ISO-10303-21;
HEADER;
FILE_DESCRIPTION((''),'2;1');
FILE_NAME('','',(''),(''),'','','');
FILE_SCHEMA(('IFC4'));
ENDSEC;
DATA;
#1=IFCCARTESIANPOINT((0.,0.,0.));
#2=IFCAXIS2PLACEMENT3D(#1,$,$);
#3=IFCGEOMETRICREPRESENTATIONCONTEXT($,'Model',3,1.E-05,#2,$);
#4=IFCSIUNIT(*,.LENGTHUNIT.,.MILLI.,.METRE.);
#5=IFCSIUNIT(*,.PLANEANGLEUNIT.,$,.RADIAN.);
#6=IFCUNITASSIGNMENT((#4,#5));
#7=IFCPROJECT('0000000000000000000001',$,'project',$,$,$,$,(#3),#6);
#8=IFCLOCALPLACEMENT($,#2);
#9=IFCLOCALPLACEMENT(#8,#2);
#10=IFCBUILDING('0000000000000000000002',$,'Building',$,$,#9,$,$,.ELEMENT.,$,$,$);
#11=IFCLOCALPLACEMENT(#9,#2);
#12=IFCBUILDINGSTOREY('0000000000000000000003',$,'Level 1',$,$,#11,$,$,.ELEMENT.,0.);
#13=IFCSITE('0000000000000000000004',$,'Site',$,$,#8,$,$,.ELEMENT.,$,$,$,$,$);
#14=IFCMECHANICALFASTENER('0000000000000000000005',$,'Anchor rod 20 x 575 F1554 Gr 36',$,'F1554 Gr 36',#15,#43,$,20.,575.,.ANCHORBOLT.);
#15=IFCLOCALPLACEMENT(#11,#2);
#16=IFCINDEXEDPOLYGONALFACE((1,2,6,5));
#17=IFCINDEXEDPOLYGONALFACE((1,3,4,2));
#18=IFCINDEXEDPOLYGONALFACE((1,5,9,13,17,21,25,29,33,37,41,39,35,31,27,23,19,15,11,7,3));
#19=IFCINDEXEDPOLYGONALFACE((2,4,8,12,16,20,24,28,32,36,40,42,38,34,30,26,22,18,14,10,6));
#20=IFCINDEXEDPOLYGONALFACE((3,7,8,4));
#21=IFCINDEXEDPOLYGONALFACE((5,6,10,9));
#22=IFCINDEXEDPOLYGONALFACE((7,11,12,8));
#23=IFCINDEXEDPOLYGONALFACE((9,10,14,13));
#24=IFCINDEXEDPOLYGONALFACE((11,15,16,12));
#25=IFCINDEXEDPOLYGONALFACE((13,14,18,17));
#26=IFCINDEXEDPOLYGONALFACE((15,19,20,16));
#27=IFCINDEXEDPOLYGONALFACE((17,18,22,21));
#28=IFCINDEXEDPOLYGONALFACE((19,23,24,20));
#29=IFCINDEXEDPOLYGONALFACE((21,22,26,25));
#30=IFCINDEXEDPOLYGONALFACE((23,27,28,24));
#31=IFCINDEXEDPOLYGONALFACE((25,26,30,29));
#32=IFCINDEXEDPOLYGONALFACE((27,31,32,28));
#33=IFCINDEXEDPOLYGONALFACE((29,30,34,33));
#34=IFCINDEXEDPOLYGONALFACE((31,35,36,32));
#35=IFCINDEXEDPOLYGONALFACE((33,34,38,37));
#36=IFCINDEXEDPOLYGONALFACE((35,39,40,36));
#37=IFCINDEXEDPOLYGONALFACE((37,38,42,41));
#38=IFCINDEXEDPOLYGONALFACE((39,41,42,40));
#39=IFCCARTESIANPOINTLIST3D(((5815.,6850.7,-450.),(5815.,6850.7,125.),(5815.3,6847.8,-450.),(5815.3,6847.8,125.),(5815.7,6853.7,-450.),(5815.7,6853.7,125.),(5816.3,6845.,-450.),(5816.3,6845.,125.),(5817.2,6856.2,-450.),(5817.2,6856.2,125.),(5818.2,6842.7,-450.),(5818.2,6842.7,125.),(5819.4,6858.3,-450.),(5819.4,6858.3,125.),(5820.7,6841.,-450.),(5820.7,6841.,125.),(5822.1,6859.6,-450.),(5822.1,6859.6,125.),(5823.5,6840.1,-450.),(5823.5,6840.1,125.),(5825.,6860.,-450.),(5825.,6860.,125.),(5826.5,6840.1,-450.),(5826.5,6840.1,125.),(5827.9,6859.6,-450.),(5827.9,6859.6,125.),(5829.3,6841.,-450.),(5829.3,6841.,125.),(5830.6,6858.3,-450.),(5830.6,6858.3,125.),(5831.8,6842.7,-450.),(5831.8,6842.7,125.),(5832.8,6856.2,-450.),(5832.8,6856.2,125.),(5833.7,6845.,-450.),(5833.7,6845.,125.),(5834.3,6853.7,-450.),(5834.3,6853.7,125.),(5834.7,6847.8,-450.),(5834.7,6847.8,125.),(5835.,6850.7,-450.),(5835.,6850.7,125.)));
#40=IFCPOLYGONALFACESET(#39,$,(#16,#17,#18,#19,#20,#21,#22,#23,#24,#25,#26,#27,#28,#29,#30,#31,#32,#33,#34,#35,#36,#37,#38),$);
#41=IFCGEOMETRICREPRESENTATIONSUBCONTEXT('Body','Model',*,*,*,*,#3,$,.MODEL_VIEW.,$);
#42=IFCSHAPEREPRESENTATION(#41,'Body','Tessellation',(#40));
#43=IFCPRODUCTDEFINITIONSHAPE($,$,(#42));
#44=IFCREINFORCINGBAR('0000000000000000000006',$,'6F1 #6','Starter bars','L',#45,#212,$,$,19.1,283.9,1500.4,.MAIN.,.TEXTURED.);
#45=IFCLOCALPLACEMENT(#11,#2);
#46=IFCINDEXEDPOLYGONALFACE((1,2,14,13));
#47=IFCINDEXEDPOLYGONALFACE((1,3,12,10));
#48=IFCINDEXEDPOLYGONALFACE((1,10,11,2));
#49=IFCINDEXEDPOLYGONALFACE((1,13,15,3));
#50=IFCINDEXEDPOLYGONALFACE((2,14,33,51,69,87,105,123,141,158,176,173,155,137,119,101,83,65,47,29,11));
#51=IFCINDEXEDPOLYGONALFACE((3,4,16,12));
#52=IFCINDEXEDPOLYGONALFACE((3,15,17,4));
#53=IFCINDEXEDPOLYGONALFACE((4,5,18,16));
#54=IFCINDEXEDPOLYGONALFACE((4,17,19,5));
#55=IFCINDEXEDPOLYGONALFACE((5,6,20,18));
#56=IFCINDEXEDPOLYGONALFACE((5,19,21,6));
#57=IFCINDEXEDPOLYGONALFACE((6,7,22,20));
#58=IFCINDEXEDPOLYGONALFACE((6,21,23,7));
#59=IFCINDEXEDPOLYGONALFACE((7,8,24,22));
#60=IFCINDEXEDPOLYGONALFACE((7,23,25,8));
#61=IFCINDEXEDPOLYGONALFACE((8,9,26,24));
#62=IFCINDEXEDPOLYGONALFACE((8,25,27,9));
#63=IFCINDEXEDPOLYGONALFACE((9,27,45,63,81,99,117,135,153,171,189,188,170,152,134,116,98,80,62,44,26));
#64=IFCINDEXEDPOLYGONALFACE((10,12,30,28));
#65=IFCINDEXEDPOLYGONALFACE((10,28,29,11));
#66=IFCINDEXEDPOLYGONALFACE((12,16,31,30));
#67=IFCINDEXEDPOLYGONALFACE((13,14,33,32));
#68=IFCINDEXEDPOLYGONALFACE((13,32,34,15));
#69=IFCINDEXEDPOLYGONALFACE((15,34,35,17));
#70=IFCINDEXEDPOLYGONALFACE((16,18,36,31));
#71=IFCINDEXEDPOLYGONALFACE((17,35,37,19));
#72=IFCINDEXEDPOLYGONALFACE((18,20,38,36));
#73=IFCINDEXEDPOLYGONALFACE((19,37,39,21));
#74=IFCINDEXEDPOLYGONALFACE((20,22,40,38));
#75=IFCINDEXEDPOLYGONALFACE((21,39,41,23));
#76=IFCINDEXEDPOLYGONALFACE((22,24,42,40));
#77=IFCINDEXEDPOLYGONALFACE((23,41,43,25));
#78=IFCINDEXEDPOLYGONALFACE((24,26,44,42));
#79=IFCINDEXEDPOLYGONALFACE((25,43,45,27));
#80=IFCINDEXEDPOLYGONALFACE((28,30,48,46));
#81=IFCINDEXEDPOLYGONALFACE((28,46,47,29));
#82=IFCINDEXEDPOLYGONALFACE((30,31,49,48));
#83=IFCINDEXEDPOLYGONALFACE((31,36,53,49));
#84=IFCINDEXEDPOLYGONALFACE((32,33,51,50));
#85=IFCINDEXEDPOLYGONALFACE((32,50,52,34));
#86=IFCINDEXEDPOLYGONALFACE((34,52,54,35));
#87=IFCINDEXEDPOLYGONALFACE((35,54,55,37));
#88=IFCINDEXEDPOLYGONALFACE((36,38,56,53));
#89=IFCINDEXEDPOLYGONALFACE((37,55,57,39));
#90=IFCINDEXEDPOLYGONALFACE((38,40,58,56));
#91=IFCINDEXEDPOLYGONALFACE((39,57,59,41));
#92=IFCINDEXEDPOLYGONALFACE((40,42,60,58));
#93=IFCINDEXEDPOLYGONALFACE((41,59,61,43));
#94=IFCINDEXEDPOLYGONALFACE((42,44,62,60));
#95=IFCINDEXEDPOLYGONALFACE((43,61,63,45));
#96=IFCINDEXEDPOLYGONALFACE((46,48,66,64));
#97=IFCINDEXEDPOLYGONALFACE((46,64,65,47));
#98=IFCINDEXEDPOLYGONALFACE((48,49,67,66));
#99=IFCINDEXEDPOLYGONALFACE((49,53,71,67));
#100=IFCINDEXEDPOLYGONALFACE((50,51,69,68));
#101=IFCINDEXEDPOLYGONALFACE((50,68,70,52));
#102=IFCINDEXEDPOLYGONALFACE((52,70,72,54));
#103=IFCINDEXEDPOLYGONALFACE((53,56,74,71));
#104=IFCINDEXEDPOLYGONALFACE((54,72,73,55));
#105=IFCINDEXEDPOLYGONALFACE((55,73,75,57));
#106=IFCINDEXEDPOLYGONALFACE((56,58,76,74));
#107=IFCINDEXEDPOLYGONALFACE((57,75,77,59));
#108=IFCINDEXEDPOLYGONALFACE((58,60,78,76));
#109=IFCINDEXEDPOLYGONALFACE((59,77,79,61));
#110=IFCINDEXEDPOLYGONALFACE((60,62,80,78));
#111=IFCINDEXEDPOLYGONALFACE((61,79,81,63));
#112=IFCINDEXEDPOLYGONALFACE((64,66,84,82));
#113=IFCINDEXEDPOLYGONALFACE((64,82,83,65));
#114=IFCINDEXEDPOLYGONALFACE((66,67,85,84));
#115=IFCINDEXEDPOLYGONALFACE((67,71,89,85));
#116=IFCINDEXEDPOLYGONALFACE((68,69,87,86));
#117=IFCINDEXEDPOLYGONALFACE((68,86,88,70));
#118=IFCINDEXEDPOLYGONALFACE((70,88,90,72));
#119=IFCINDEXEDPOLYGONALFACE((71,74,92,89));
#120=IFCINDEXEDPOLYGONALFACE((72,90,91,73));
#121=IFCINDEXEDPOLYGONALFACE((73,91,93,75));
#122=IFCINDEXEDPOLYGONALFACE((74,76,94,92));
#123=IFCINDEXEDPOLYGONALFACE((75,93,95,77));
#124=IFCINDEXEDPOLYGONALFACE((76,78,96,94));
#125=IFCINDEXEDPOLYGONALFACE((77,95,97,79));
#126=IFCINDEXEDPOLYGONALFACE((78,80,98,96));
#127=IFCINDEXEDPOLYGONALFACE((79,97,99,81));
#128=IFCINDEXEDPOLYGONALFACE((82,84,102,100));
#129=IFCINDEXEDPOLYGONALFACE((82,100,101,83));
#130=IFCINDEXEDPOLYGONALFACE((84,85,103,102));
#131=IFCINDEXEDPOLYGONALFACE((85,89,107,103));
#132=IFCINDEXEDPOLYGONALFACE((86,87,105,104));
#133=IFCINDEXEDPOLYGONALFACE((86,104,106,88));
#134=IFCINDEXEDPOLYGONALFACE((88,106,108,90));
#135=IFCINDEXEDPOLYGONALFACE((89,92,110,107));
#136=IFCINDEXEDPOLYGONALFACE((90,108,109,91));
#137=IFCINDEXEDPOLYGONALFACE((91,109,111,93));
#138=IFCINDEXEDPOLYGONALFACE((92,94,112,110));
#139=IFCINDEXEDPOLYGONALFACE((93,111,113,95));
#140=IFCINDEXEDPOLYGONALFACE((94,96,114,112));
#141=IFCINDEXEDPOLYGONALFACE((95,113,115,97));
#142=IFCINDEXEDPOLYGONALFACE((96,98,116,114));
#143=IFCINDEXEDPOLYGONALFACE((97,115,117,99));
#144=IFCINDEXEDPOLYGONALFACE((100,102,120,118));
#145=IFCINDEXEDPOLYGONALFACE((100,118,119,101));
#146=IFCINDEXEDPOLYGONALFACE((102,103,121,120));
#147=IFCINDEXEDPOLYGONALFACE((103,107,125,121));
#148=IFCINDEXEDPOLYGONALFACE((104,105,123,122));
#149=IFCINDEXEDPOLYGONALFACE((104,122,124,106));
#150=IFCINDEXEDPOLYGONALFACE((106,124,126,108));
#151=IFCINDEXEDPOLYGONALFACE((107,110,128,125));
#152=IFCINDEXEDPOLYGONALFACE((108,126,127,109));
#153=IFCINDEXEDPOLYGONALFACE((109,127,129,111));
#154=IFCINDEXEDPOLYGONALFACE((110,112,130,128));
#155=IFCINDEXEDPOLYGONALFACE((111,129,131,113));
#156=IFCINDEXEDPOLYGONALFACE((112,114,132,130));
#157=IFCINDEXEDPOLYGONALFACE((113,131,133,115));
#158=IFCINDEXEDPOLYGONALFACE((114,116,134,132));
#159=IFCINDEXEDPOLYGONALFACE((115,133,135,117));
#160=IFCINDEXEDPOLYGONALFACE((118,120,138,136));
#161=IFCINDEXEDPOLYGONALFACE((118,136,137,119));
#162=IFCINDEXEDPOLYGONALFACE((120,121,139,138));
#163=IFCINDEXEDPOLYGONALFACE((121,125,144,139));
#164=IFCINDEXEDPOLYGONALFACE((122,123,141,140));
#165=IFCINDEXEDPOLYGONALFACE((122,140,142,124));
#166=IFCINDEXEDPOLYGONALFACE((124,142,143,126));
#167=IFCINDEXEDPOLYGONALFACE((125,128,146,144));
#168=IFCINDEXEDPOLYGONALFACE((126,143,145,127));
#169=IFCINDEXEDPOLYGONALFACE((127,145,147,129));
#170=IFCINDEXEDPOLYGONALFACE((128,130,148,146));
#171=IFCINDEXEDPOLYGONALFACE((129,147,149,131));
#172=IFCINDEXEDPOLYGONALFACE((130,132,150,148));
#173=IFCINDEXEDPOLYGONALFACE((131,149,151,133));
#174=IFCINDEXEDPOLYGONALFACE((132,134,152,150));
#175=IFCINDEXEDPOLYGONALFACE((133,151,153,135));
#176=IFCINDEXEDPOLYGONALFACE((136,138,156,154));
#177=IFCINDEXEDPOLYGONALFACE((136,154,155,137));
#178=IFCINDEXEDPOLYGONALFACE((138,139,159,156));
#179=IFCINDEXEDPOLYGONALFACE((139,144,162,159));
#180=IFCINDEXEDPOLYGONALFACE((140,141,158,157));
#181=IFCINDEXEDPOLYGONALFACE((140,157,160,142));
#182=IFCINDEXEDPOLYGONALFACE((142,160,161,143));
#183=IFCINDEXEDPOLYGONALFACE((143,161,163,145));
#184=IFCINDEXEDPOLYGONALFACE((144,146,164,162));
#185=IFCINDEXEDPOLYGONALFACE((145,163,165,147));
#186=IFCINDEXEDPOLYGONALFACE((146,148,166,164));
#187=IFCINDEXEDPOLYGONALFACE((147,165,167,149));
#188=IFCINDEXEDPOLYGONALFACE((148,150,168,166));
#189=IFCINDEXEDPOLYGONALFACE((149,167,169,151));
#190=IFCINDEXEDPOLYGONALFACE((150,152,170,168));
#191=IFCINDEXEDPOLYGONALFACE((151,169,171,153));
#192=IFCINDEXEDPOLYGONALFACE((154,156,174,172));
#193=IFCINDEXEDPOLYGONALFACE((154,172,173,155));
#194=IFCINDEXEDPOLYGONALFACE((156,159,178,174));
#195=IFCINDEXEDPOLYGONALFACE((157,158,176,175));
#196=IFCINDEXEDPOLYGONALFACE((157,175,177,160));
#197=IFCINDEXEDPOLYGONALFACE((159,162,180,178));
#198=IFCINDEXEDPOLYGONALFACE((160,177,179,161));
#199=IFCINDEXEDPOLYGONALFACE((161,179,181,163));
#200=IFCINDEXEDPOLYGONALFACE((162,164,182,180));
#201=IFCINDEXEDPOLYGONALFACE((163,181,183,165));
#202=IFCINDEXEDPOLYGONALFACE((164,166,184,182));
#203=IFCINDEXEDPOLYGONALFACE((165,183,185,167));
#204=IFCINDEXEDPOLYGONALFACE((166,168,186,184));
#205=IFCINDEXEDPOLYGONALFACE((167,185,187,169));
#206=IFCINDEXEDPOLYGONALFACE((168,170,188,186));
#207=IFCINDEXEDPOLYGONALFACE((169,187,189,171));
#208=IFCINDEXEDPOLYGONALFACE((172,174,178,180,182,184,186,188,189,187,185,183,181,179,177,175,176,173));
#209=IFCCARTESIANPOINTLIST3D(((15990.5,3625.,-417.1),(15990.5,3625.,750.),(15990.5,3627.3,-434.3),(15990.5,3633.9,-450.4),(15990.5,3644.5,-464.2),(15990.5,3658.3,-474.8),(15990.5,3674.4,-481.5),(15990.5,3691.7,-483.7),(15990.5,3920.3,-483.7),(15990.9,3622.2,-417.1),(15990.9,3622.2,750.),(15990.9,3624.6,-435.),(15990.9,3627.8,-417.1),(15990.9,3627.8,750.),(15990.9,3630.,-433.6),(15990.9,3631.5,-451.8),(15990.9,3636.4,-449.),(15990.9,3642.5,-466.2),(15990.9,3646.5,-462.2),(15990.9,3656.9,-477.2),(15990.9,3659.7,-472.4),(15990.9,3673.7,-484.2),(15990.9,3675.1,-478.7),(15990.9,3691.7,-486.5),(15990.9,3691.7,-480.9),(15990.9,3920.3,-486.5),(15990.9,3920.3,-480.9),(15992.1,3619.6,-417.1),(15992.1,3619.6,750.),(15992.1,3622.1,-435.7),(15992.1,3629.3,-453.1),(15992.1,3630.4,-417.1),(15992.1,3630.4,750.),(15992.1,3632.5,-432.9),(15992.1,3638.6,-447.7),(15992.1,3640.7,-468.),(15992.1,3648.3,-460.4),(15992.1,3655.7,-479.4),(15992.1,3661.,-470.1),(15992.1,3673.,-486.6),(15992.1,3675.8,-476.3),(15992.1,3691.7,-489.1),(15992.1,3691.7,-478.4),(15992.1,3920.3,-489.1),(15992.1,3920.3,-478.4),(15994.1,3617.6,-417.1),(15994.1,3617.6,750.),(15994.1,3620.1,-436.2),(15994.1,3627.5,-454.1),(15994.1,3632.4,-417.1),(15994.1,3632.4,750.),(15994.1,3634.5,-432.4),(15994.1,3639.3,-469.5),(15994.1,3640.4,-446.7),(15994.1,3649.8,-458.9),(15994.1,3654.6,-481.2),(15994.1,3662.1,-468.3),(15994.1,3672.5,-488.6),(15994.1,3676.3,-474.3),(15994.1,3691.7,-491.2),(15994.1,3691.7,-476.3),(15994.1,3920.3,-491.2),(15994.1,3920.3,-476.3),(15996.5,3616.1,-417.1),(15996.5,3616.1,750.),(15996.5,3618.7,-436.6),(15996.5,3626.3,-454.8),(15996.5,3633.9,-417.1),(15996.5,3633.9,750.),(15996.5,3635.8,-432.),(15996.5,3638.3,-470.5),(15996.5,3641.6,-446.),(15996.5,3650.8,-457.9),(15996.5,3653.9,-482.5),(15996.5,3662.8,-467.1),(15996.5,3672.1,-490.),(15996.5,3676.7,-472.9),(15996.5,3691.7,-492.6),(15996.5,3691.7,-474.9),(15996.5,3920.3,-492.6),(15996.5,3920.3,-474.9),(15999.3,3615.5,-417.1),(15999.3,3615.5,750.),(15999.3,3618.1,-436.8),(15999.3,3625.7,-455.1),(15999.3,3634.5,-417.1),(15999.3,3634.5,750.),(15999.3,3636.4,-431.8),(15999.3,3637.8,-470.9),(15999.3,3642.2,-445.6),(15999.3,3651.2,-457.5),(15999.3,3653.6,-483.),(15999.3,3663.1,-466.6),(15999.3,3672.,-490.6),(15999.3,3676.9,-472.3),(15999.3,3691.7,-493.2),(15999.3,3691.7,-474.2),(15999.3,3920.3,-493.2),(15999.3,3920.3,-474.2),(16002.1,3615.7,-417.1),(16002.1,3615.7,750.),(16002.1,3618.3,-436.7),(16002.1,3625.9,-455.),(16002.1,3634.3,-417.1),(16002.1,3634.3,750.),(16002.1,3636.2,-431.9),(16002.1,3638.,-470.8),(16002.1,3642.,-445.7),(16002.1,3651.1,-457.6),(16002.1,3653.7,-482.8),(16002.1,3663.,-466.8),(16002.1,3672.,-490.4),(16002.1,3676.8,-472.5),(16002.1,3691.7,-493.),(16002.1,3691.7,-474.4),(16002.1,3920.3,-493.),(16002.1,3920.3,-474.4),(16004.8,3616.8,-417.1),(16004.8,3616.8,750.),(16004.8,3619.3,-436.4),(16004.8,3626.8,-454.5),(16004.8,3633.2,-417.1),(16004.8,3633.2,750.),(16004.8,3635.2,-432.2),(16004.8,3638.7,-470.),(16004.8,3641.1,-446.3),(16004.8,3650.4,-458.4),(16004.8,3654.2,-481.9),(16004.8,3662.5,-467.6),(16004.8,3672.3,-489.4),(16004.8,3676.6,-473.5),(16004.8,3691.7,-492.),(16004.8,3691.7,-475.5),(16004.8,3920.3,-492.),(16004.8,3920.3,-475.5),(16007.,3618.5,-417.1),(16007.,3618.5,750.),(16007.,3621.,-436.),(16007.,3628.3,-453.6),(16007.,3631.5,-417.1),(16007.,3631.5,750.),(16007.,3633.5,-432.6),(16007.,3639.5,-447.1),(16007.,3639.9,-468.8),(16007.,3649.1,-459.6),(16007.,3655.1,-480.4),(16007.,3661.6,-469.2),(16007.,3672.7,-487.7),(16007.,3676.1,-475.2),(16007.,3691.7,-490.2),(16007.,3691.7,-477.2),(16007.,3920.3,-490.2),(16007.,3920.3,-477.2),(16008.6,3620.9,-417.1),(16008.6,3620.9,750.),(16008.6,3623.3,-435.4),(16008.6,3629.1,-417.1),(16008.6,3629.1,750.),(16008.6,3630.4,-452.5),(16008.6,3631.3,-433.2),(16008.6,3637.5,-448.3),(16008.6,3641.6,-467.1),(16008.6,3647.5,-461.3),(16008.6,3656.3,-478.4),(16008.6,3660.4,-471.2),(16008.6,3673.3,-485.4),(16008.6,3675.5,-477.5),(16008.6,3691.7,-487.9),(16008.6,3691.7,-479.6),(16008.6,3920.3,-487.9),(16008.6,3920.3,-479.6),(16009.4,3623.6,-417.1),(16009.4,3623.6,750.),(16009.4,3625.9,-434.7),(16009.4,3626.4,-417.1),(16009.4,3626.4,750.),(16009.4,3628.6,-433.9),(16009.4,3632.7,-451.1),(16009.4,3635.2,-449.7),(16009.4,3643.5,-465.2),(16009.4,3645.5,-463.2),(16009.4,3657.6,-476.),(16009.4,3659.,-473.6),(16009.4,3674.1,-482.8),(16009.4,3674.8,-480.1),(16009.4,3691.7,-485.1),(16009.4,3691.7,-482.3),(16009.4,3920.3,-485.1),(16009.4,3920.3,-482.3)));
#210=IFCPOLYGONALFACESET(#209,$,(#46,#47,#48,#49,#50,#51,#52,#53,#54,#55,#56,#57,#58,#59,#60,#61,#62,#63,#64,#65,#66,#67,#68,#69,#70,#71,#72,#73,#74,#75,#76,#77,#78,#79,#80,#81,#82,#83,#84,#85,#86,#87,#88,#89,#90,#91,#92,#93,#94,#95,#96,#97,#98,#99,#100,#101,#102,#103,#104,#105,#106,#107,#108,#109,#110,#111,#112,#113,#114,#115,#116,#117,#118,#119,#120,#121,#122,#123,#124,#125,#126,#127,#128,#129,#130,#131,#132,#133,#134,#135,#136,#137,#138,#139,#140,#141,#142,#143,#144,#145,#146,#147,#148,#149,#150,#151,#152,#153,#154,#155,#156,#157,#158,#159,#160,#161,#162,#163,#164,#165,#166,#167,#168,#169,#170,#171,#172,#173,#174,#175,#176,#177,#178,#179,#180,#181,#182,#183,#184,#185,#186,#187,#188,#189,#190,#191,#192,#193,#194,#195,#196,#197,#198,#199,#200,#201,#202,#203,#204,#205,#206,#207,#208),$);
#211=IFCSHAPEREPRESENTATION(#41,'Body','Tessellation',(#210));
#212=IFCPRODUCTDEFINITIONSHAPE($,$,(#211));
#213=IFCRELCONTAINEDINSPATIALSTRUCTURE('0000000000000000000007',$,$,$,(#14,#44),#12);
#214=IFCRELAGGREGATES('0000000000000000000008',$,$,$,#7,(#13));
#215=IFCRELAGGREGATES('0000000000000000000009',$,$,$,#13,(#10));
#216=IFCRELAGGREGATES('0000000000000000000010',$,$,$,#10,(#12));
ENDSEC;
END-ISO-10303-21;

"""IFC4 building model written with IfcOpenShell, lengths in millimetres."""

from ifc_helpers import new_model, entity, si_unit, frame, origin, origin_2d, place, context, subcontext, project, spatial, circle, extrude, element, save


model = new_model("IFC4")

# Units and contexts
model_context = context("Model", 3, precision=1e-05, world=origin())
body_context = subcontext(model_context, "Body", "Model", "MODEL_VIEW")
ifc_project = project(units=[si_unit("LENGTHUNIT", "METRE", prefix="MILLI"), si_unit("PLANEANGLEUNIT", "RADIAN")], contexts=[model_context])

# Site, building, storey
site_placement = place(None, origin())
site = spatial("IfcSite", under=ifc_project, at=site_placement, Name="Site", CompositionType="ELEMENT")
building_placement = place(site_placement, origin())
building = spatial("IfcBuilding", under=site, at=building_placement, Name="Building", CompositionType="ELEMENT")
storey_placement = place(building_placement, origin())
storey = spatial("IfcBuildingStorey", under=building, at=storey_placement, Name="Level 1", CompositionType="ELEMENT", Elevation=0.0)

# Mechanical fastener
for number, where, z_axis, x_axis, name in (
    (1, (5825.0, 6850.0, 125.0), (0.0, 0.0, -1.0), (0.0, 1.0, 0.0), "Anchor rod 20 x 575 F1554 Gr 36"),
):
    element("IfcMechanicalFastener", number, at=place(storey_placement, frame(where, z_axis=z_axis, x_axis=x_axis)), inside=storey, Name=name, ObjectType="F1554 Gr 36", NominalDiameter=20.0, NominalLength=575.0, PredefinedType="ANCHORBOLT", context=body_context, shape_type="SweptSolid", body=[
        extrude(circle(Radius=10.0, at=origin_2d()), origin(), (0.0, 0.0, 1.0), 575.0),
    ])

# Reinforcing bar
reinforcing_bar_1_placement = place(storey_placement, origin())
element("IfcReinforcingBar", 2, at=reinforcing_bar_1_placement, inside=storey, Name="6F1 #6", Description="Starter bars", ObjectType="L", BarLength=1500.4, BarSurface="TEXTURED", CrossSectionArea=283.9, NominalDiameter=19.1, PredefinedType="MAIN", context=body_context, shape_type="AdvancedSweptSolid", body=[
    entity("IfcSweptDiskSolid", entity("IfcIndexedPolyCurve", entity("IfcCartesianPointList3D", [[16000.0, 3625.0, 750.0], [16000.0, 3625.0, -417.1], [16000.0, 3644.5, -464.2], [16000.0, 3691.7, -483.7], [16000.0, 3920.3, -483.7]]), [entity("IfcLineIndex", [1, 2]), entity("IfcArcIndex", [2, 3, 4]), entity("IfcLineIndex", [4, 5])], False), 9.5),
])

save(model, "model.ifc")
